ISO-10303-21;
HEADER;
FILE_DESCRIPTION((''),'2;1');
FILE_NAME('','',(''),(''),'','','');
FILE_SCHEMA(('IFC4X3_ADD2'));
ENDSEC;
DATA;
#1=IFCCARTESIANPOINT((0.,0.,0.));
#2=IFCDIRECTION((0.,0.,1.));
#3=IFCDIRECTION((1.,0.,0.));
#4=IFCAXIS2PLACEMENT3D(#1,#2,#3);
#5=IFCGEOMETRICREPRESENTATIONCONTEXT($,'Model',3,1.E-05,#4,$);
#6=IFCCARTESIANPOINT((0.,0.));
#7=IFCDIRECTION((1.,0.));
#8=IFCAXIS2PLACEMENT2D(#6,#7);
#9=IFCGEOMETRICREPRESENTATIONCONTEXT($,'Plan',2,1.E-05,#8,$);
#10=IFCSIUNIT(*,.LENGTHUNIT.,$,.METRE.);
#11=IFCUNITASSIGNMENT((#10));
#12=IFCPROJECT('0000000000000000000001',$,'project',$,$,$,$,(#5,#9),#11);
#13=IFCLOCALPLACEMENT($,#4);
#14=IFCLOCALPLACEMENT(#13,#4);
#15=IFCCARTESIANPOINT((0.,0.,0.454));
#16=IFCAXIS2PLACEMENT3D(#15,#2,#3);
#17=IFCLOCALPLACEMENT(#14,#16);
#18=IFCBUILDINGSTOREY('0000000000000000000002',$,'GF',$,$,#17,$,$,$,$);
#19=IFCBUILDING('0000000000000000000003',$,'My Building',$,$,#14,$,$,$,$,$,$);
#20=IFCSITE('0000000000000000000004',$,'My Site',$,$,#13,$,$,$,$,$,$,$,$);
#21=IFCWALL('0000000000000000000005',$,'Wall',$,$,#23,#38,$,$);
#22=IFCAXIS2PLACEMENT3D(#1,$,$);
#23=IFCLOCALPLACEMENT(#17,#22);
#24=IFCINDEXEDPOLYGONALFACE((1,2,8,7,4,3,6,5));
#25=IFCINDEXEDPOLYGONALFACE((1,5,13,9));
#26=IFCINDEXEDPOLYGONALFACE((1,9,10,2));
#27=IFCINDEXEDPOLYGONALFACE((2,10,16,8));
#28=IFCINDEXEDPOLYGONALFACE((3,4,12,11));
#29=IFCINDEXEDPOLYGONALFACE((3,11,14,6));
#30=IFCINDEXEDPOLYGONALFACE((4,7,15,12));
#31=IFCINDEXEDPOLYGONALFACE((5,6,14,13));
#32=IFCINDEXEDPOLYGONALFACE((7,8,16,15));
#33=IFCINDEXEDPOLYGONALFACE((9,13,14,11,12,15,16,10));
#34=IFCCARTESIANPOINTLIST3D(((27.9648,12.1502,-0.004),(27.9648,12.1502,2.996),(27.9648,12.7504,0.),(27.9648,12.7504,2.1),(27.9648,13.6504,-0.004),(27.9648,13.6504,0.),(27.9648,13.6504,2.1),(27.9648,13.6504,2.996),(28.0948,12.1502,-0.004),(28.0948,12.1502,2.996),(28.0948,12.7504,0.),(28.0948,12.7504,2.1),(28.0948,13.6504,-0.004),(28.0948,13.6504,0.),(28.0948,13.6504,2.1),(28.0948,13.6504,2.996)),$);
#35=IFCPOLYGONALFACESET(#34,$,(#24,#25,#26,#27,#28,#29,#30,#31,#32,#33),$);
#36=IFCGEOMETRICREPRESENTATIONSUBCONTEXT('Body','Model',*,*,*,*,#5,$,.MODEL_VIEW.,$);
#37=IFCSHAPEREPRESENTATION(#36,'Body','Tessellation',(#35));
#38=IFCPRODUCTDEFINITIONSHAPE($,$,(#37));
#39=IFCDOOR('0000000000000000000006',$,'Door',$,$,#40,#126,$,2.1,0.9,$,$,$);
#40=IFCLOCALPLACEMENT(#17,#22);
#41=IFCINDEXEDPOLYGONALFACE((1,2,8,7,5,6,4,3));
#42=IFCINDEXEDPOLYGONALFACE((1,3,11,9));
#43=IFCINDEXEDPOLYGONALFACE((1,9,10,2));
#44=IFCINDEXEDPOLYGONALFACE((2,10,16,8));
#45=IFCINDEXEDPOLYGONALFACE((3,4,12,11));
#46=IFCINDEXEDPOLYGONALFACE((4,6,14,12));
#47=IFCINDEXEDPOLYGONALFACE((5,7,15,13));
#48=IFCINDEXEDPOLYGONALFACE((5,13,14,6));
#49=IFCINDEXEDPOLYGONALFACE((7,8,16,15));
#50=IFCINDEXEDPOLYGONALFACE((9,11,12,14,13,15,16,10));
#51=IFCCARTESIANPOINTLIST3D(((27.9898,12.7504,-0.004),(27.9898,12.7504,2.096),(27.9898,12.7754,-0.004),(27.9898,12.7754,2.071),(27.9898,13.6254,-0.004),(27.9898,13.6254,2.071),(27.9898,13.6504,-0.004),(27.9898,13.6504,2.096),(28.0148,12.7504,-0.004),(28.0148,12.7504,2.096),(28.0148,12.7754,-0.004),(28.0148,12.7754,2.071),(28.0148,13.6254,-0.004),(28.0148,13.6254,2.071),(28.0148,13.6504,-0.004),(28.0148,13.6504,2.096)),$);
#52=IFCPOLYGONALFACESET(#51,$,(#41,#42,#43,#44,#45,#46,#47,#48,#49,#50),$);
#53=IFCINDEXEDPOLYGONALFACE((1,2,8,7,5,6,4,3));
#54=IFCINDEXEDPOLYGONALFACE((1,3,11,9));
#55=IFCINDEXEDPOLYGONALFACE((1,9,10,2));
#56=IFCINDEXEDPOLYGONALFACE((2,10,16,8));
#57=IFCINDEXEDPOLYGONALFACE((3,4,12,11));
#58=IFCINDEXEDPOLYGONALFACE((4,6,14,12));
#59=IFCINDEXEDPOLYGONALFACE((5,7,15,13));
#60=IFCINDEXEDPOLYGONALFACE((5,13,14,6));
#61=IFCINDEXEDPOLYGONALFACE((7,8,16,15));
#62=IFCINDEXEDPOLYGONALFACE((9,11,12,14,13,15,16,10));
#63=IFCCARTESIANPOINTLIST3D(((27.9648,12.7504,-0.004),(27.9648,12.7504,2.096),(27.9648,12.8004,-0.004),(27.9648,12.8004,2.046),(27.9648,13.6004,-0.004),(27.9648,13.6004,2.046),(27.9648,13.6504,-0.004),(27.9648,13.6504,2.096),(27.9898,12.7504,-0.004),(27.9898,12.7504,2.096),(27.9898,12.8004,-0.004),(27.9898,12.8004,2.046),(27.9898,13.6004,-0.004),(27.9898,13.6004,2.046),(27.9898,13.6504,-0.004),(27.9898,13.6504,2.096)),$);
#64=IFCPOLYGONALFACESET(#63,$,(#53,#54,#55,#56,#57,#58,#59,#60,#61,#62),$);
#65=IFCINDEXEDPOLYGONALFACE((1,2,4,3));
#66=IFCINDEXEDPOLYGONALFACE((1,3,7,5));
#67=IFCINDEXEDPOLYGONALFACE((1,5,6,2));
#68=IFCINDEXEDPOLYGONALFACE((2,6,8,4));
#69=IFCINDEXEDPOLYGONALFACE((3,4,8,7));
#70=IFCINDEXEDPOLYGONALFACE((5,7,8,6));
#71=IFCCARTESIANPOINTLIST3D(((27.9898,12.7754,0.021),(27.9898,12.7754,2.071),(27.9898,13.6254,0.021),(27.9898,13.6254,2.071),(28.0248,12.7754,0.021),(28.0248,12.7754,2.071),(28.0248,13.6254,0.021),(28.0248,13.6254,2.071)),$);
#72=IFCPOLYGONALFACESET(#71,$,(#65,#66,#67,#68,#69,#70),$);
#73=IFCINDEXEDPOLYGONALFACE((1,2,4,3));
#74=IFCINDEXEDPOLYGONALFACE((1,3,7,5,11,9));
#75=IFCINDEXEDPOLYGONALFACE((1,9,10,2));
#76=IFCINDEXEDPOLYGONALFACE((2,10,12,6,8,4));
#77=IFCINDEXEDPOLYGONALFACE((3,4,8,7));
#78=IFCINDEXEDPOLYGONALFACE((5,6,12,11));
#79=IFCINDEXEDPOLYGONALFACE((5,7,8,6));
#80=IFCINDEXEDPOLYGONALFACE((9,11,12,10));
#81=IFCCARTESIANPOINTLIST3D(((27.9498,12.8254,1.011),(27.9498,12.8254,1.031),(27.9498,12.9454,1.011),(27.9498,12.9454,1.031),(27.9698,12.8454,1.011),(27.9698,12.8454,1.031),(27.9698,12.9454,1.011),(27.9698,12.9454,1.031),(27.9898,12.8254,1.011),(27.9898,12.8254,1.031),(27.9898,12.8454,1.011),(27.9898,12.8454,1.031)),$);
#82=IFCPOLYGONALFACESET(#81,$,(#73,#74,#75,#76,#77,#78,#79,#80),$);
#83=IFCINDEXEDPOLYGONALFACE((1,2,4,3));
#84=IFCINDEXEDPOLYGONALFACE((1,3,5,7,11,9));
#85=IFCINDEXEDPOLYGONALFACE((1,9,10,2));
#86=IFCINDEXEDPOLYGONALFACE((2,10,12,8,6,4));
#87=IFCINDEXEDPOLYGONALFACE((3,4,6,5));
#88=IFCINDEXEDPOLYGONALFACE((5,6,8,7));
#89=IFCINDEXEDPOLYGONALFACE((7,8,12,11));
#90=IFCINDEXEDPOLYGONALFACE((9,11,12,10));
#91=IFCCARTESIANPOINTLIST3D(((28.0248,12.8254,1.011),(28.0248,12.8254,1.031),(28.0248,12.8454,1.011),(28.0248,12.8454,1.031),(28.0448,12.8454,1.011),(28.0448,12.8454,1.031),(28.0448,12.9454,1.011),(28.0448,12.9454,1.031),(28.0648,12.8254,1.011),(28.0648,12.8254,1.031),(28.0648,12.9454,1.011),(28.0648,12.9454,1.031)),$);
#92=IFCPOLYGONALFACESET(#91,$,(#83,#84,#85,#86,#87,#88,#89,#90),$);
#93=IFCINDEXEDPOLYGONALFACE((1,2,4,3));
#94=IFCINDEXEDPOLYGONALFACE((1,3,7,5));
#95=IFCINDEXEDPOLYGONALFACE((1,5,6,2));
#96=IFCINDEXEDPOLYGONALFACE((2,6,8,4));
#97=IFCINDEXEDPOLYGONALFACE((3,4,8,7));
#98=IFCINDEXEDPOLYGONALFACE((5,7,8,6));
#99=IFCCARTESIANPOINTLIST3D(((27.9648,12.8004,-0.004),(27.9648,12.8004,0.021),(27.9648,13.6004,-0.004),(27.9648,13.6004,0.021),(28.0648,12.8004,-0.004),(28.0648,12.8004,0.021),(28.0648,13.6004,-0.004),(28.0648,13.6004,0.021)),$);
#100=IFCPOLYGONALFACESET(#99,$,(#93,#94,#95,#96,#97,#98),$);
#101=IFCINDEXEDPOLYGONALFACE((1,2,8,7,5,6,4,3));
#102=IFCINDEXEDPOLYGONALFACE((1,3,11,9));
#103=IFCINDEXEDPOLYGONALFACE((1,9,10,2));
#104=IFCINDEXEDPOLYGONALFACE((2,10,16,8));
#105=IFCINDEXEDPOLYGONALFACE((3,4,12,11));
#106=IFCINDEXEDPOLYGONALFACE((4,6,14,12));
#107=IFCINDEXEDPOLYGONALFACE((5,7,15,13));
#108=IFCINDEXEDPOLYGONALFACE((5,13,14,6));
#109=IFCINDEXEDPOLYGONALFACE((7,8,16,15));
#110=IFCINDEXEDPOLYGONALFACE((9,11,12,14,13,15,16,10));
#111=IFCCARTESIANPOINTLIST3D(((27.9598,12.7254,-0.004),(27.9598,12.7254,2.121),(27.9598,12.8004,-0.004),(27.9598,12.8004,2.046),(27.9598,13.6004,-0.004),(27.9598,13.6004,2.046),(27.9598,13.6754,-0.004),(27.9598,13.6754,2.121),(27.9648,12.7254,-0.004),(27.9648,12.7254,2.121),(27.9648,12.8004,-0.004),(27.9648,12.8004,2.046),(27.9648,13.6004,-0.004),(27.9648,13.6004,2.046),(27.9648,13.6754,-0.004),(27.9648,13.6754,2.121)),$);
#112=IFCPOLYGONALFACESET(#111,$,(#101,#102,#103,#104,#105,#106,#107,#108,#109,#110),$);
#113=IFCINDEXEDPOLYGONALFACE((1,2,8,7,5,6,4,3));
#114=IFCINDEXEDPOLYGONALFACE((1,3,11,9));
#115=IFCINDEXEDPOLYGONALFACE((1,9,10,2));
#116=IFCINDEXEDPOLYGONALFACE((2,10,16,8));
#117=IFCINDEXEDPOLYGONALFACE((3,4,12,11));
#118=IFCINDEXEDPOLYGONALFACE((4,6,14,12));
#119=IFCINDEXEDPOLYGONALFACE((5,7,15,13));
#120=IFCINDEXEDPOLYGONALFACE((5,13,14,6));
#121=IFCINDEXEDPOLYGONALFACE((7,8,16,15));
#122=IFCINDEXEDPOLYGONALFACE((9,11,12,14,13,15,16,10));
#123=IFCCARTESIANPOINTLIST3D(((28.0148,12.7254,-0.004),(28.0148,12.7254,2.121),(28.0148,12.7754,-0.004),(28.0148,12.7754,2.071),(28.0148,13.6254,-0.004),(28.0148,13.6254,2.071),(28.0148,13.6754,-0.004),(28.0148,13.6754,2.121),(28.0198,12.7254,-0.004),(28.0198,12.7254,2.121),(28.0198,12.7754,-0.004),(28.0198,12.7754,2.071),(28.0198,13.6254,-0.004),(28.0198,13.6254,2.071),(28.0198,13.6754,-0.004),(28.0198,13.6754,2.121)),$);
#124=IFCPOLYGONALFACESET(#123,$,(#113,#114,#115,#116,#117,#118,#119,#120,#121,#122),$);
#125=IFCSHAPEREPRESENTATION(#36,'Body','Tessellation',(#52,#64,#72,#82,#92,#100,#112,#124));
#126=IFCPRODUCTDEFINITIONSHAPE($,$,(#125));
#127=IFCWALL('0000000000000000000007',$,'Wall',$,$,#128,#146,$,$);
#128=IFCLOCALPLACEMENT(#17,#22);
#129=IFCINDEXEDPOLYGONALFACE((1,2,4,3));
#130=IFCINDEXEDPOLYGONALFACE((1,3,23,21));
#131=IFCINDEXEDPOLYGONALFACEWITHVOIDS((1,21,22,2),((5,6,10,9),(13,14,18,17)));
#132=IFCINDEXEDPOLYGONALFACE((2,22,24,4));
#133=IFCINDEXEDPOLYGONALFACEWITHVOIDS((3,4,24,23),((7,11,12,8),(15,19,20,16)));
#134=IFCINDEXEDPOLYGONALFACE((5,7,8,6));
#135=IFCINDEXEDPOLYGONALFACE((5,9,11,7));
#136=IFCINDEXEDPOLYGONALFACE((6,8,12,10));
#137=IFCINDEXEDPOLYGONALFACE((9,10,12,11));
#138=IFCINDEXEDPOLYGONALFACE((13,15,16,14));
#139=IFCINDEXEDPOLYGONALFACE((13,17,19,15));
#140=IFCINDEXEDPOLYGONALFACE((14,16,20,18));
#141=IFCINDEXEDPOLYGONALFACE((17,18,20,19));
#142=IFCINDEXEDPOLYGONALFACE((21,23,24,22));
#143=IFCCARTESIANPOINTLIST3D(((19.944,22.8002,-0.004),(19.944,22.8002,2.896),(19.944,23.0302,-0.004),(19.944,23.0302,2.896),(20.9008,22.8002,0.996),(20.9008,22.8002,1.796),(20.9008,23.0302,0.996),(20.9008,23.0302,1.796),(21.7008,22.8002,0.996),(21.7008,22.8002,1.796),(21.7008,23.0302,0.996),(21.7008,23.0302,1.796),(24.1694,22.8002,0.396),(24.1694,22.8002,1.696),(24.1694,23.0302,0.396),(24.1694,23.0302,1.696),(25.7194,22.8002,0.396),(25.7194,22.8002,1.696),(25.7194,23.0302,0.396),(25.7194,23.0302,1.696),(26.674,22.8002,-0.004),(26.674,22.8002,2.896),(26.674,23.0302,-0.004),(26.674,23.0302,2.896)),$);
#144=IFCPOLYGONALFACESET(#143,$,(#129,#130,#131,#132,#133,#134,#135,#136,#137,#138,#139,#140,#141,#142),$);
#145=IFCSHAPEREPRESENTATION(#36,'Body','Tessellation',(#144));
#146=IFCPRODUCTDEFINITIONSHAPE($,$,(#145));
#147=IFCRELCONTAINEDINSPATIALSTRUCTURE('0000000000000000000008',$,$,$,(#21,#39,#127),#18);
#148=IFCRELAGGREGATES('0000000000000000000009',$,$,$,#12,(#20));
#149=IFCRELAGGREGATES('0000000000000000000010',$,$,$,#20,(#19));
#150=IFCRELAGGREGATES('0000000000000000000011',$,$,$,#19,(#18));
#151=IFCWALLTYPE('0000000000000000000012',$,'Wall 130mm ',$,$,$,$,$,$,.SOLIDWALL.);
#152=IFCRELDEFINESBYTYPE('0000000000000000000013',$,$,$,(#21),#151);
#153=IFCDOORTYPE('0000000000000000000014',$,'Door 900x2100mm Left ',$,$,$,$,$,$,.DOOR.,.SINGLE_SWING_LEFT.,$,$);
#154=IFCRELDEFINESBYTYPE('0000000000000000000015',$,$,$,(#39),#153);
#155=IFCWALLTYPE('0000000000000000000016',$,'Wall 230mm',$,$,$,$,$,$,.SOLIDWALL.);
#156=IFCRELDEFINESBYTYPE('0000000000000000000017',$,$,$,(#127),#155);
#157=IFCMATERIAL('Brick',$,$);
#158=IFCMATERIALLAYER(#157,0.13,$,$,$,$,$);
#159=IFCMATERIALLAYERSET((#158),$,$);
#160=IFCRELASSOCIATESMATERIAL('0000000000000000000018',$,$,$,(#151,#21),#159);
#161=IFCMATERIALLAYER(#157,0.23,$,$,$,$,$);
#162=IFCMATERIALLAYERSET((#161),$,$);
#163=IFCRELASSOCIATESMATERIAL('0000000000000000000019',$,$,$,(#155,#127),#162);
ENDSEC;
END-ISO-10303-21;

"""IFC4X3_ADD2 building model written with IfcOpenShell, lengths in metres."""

from ifc_helpers import new_model, entity, si_unit, frame, origin_with_axes, origin_2d_with_axis, place, context, subcontext, project, spatial, line, indexed_curve, outline, extrude, shape, source, transform, mapped, material, layer, layer_set, layer_usage, type_object, type_shapes, element, fill, save


model = new_model("IFC4X3_ADD2")

# Units and contexts
model_context = context("Model", 3, precision=1e-05, world=origin_with_axes())
plan_context = context("Plan", 2, precision=1e-05, world=origin_2d_with_axis())
body_context_1 = subcontext(model_context, "Body", "Model", "MODEL_VIEW")
body_context_2 = subcontext(plan_context, "Body", "Plan", "PLAN_VIEW")
ifc_project = project(units=[si_unit("LENGTHUNIT", "METRE")], contexts=[model_context, plan_context])

# Site, building, storey
site_placement = place(None, origin_with_axes())
site = spatial("IfcSite", under=ifc_project, at=site_placement, Name="My Site")
building_placement = place(site_placement, origin_with_axes())
building = spatial("IfcBuilding", under=site, at=building_placement, Name="My Building")
storey_placement = place(building_placement, frame((0.0, 0.0, 0.454), z_axis=(0.0, 0.0, 1.0), x_axis=(1.0, 0.0, 0.0)))
storey = spatial("IfcBuildingStorey", under=building, at=storey_placement, Name="GF")

# Shared definitions
ifc_material_1 = material(Name="Brick")
ifc_layer_1 = layer(ifc_material_1, 0.13)
ifc_layer_set_1 = layer_set([ifc_layer_1])
wall_type_1 = type_object("IfcWallType", Name="Wall 130mm ", PredefinedType="SOLIDWALL", material=ifc_layer_set_1)

# Wall, opening, door
ifc_layer_usage_1 = layer_usage(ifc_layer_set_1, "AXIS2", "POSITIVE", 0.0)
wall_1_placement = place(storey_placement, frame((27.9648, 13.6504, -0.004), z_axis=(0.0, 0.0, 1.0), x_axis=(0.0, -1.0, 0.0)))
wall_1 = element("IfcWall", 1, at=wall_1_placement, inside=storey, type_object=wall_type_1, material=ifc_layer_usage_1, Name="Wall", context=body_context_1, shape_type="SweptSolid", body=[
    extrude(outline(indexed_curve([(0.0, 0.0), (0.0, 0.13), (1.5002, 0.13), (1.5002, 0.0), (0.0, 0.0)], self_intersect=False)), origin_with_axes(), (0.0, 0.0, 1.0), 3.0),
])
shared_shape_1 = source(origin_with_axes(), body_context_1, "Body", "SweptSolid", [
    extrude(outline(indexed_curve([(0.0, 0.0), (0.9, 0.0), (0.9, 2.1), (0.0, 2.1)], segments=[line(1, 2, 3, 4, 1)])), frame((0.0, -0.6, 0.0), z_axis=(0.0, -1.0, 0.0), x_axis=(1.0, 0.0, 0.0)), (0.0, 0.0, -1.0), 1.2),
])
opening_1_placement = place(wall_1_placement, frame((0.0, 0.0, 0.004), z_axis=(0.0, 0.0, 1.0), x_axis=(1.0, 0.0, 0.0)))
opening_1 = element("IfcOpeningElement", 2, at=opening_1_placement, cuts=wall_1, PredefinedType="OPENING", context=body_context_1, shape_type="MappedRepresentation", body=[
    mapped(shared_shape_1, transform((0.0, 0.0, 0.0), x_axis=(1.0, 0.0, 0.0), y_axis=(0.0, 1.0, 0.0), z_axis=(0.0, 0.0, 1.0), scale=1.0)),
])
door_type = type_object("IfcDoorType", Name="Door 900x2100mm Left ", OperationType="SINGLE_SWING_LEFT", PredefinedType="DOOR")
shared_shape_2 = source(origin_with_axes(), body_context_1, "Body", "SweptSolid", [
    extrude(outline(indexed_curve([(0.0, 0.0), (0.0, 2.1), (0.9, 2.1), (0.9, 0.0), (0.875, 0.0), (0.875, 2.075), (0.025, 2.075), (0.025, 0.0)], segments=[line(1, 2, 3, 4, 5, 6, 7, 8, 1)])), frame((0.0, 0.025, 0.0), z_axis=(0.0, -1.0, 0.0), x_axis=(1.0, 0.0, 0.0)), (0.0, 0.0, -1.0), 0.025),
    extrude(outline(indexed_curve([(0.0, 0.0), (0.0, 2.1), (0.9, 2.1), (0.9, 0.0), (0.85, 0.0), (0.85, 2.05), (0.05, 2.05), (0.05, 0.0)], segments=[line(1, 2, 3, 4, 5, 6, 7, 8, 1)])), frame((0.0, 0.0, 0.0), z_axis=(0.0, -1.0, 0.0), x_axis=(1.0, 0.0, 0.0)), (0.0, 0.0, -1.0), 0.025),
    extrude(outline(indexed_curve([(0.0, 0.0), (0.85, 0.0), (0.85, 0.035), (0.0, 0.035)], segments=[line(1, 2, 3, 4, 1)])), frame((0.025, 0.025, 0.025), z_axis=(0.0, 0.0, 1.0), x_axis=(1.0, 0.0, 0.0)), (0.0, 0.0, 1.0), 2.05),
    extrude(outline(indexed_curve([(0.0, 0.0), (0.0, -0.04), (-0.12, -0.04), (-0.12, -0.02), (-0.02, -0.02), (-0.02, 0.0)], segments=[line(1, 2, 3, 4, 5, 6, 1)])), frame((0.825, 0.025, 1.015), z_axis=(0.0, 0.0, 1.0), x_axis=(1.0, 0.0, 0.0)), (0.0, 0.0, 1.0), 0.02),
    extrude(outline(indexed_curve([(0.0, 0.0), (0.0, 0.04), (-0.12, 0.04), (-0.12, 0.02), (-0.02, 0.02), (-0.02, 0.0)], segments=[line(1, 2, 3, 4, 5, 6, 1)])), frame((0.825, 0.06, 1.015), z_axis=(0.0, 0.0, 1.0), x_axis=(1.0, 0.0, 0.0)), (0.0, 0.0, 1.0), 0.02),
    extrude(outline(indexed_curve([(0.0, 0.0), (0.8, 0.0), (0.8, 0.1), (0.0, 0.1)], segments=[line(1, 2, 3, 4, 1)])), frame((0.05, 0.0, 0.0), z_axis=(0.0, 0.0, 1.0), x_axis=(1.0, 0.0, 0.0)), (0.0, 0.0, 1.0), 0.025),
    extrude(outline(indexed_curve([(0.0, 0.0), (0.0, 2.125), (0.95, 2.125), (0.95, 0.0), (0.875, 0.0), (0.875, 2.05), (0.075, 2.05), (0.075, 0.0)], segments=[line(1, 2, 3, 4, 5, 6, 7, 8, 1)])), frame((-0.025, -0.005, 0.0), z_axis=(0.0, -1.0, 0.0), x_axis=(1.0, 0.0, 0.0)), (0.0, 0.0, -1.0), 0.005),
    extrude(outline(indexed_curve([(0.0, 0.0), (0.0, 2.125), (0.95, 2.125), (0.95, 0.0), (0.9, 0.0), (0.9, 2.075), (0.05, 2.075), (0.05, 0.0)], segments=[line(1, 2, 3, 4, 5, 6, 7, 8, 1)])), frame((-0.025, 0.05, 0.0), z_axis=(0.0, -1.0, 0.0), x_axis=(1.0, 0.0, 0.0)), (0.0, 0.0, -1.0), 0.005),
])
shared_shape_3 = source(origin_with_axes(), body_context_2, "Body", "Curve2D", [
    entity("IfcIndexedPolyCurve", entity("IfcCartesianPointList2D", [[0.0, 0.0], [0.0, 0.05], [0.025, 0.05], [0.025, 0.025], [0.05, 0.025], [0.05, 0.0]]), [entity("IfcLineIndex", [1, 2, 3, 4, 5, 6, 1])]),
    entity("IfcIndexedPolyCurve", entity("IfcCartesianPointList2D", [[0.9, 0.0], [0.9, 0.05], [0.875, 0.05], [0.875, 0.025], [0.85, 0.025], [0.85, 0.0]]), [entity("IfcLineIndex", [1, 2, 3, 4, 5, 6, 1])]),
    entity("IfcTrimmedCurve", entity("IfcEllipse", entity("IfcAxis2Placement2D", entity("IfcCartesianPoint", [0.06, 0.05]), entity("IfcDirection", [1.0, 0.0])), 0.815, 0.85), [entity("IfcCartesianPoint", [0.875, 0.05])], [entity("IfcCartesianPoint", [0.06, 0.9])], True, "CARTESIAN"),
    entity("IfcIndexedPolyCurve", entity("IfcCartesianPointList2D", [[0.025, 0.05], [0.06, 0.05], [0.06, 0.9], [0.025, 0.9]]), [entity("IfcLineIndex", [1, 2, 3, 4, 1])]),
])
type_shapes(door_type, [shared_shape_2, shared_shape_3])
door_1_placement = place(opening_1_placement, frame((0.0, 0.0, -0.004), z_axis=(0.0, 0.0, 1.0), x_axis=(1.0, 0.0, 0.0)))
door_1 = element("IfcDoor", 3, at=door_1_placement, inside=storey, type_object=door_type, Name="Door", OverallHeight=2.1, OverallWidth=0.9, shapes=[
    shape(body_context_1, "Body", "MappedRepresentation", [mapped(shared_shape_2, transform((0.0, 0.0, 0.0), x_axis=(1.0, 0.0, 0.0), y_axis=(0.0, 1.0, 0.0), z_axis=(0.0, 0.0, 1.0), scale=1.0))]),
    shape(body_context_2, "Body", "MappedRepresentation", [mapped(shared_shape_3, transform((0.0, 0.0, 0.0), x_axis=(1.0, 0.0, 0.0), y_axis=(0.0, 1.0, 0.0), z_axis=(0.0, 0.0, 1.0), scale=1.0))]),
])
fill(opening_1, door_1)

# Wall, openings
ifc_layer_2 = layer(ifc_material_1, 0.23)
ifc_layer_set_2 = layer_set([ifc_layer_2])
ifc_layer_usage_2 = layer_usage(ifc_layer_set_2, "AXIS2", "POSITIVE", 0.0)
wall_type_2 = type_object("IfcWallType", Name="Wall 230mm", PredefinedType="SOLIDWALL", material=ifc_layer_set_2)
wall_2_placement = place(storey_placement, frame((26.674, 23.0302, -0.004), z_axis=(0.0, 0.0, 1.0), x_axis=(-1.0, 0.0, 0.0)))
wall_2 = element("IfcWall", 4, at=wall_2_placement, inside=storey, type_object=wall_type_2, material=ifc_layer_usage_2, Name="Wall", context=body_context_1, shape_type="SweptSolid", body=[
    extrude(outline(indexed_curve([(0.0, 0.0), (0.0, 0.23), (6.73, 0.23), (6.73, 0.0), (0.0, 0.0)], self_intersect=False)), origin_with_axes(), (0.0, 0.0, 1.0), 2.9),
])
shared_shape_4 = source(origin_with_axes(), body_context_1, "Body", "SweptSolid", [
    extrude(outline(indexed_curve([(0.0, 0.0), (0.8, 0.0), (0.8, 0.8), (0.0, 0.8)], segments=[line(1, 2, 3, 4, 1)])), frame((-0.4, -0.6, 0.0), z_axis=(0.0, -1.0, 0.0), x_axis=(1.0, 0.0, 0.0)), (0.0, 0.0, -1.0), 1.2),
])
opening_2_placement = place(wall_2_placement, frame((5.3732, 0.16, 1.0), z_axis=(0.0, 0.0, 1.0), x_axis=(1.0, 0.0, 0.0)))
element("IfcOpeningElement", 5, at=opening_2_placement, cuts=wall_2, PredefinedType="OPENING", context=body_context_1, shape_type="MappedRepresentation", body=[
    mapped(shared_shape_4, transform((0.0, 0.0, 0.0), x_axis=(1.0, 0.0, 0.0), y_axis=(0.0, 1.0, 0.0), z_axis=(0.0, 0.0, 1.0), scale=1.0)),
])
shared_shape_5 = source(origin_with_axes(), body_context_1, "Body", "SweptSolid", [
    extrude(outline(indexed_curve([(0.0, 0.0), (1.55, 0.0), (1.55, 1.3), (0.0, 1.3)], segments=[line(1, 2, 3, 4, 1)])), frame((-0.775, -0.6, 0.0), z_axis=(0.0, -1.0, 0.0), x_axis=(1.0, 0.0, 0.0)), (0.0, 0.0, -1.0), 1.2),
])
opening_3_placement = place(wall_2_placement, frame((1.7296, 0.0, 0.4), z_axis=(0.0, 0.0, 1.0), x_axis=(1.0, 0.0, 0.0)))
element("IfcOpeningElement", 6, at=opening_3_placement, cuts=wall_2, PredefinedType="OPENING", context=body_context_1, shape_type="MappedRepresentation", body=[
    mapped(shared_shape_5, transform((0.0, 0.0, 0.0), x_axis=(1.0, 0.0, 0.0), y_axis=(0.0, 1.0, 0.0), z_axis=(0.0, 0.0, 1.0), scale=1.0)),
])

save(model, "model.ifc")
